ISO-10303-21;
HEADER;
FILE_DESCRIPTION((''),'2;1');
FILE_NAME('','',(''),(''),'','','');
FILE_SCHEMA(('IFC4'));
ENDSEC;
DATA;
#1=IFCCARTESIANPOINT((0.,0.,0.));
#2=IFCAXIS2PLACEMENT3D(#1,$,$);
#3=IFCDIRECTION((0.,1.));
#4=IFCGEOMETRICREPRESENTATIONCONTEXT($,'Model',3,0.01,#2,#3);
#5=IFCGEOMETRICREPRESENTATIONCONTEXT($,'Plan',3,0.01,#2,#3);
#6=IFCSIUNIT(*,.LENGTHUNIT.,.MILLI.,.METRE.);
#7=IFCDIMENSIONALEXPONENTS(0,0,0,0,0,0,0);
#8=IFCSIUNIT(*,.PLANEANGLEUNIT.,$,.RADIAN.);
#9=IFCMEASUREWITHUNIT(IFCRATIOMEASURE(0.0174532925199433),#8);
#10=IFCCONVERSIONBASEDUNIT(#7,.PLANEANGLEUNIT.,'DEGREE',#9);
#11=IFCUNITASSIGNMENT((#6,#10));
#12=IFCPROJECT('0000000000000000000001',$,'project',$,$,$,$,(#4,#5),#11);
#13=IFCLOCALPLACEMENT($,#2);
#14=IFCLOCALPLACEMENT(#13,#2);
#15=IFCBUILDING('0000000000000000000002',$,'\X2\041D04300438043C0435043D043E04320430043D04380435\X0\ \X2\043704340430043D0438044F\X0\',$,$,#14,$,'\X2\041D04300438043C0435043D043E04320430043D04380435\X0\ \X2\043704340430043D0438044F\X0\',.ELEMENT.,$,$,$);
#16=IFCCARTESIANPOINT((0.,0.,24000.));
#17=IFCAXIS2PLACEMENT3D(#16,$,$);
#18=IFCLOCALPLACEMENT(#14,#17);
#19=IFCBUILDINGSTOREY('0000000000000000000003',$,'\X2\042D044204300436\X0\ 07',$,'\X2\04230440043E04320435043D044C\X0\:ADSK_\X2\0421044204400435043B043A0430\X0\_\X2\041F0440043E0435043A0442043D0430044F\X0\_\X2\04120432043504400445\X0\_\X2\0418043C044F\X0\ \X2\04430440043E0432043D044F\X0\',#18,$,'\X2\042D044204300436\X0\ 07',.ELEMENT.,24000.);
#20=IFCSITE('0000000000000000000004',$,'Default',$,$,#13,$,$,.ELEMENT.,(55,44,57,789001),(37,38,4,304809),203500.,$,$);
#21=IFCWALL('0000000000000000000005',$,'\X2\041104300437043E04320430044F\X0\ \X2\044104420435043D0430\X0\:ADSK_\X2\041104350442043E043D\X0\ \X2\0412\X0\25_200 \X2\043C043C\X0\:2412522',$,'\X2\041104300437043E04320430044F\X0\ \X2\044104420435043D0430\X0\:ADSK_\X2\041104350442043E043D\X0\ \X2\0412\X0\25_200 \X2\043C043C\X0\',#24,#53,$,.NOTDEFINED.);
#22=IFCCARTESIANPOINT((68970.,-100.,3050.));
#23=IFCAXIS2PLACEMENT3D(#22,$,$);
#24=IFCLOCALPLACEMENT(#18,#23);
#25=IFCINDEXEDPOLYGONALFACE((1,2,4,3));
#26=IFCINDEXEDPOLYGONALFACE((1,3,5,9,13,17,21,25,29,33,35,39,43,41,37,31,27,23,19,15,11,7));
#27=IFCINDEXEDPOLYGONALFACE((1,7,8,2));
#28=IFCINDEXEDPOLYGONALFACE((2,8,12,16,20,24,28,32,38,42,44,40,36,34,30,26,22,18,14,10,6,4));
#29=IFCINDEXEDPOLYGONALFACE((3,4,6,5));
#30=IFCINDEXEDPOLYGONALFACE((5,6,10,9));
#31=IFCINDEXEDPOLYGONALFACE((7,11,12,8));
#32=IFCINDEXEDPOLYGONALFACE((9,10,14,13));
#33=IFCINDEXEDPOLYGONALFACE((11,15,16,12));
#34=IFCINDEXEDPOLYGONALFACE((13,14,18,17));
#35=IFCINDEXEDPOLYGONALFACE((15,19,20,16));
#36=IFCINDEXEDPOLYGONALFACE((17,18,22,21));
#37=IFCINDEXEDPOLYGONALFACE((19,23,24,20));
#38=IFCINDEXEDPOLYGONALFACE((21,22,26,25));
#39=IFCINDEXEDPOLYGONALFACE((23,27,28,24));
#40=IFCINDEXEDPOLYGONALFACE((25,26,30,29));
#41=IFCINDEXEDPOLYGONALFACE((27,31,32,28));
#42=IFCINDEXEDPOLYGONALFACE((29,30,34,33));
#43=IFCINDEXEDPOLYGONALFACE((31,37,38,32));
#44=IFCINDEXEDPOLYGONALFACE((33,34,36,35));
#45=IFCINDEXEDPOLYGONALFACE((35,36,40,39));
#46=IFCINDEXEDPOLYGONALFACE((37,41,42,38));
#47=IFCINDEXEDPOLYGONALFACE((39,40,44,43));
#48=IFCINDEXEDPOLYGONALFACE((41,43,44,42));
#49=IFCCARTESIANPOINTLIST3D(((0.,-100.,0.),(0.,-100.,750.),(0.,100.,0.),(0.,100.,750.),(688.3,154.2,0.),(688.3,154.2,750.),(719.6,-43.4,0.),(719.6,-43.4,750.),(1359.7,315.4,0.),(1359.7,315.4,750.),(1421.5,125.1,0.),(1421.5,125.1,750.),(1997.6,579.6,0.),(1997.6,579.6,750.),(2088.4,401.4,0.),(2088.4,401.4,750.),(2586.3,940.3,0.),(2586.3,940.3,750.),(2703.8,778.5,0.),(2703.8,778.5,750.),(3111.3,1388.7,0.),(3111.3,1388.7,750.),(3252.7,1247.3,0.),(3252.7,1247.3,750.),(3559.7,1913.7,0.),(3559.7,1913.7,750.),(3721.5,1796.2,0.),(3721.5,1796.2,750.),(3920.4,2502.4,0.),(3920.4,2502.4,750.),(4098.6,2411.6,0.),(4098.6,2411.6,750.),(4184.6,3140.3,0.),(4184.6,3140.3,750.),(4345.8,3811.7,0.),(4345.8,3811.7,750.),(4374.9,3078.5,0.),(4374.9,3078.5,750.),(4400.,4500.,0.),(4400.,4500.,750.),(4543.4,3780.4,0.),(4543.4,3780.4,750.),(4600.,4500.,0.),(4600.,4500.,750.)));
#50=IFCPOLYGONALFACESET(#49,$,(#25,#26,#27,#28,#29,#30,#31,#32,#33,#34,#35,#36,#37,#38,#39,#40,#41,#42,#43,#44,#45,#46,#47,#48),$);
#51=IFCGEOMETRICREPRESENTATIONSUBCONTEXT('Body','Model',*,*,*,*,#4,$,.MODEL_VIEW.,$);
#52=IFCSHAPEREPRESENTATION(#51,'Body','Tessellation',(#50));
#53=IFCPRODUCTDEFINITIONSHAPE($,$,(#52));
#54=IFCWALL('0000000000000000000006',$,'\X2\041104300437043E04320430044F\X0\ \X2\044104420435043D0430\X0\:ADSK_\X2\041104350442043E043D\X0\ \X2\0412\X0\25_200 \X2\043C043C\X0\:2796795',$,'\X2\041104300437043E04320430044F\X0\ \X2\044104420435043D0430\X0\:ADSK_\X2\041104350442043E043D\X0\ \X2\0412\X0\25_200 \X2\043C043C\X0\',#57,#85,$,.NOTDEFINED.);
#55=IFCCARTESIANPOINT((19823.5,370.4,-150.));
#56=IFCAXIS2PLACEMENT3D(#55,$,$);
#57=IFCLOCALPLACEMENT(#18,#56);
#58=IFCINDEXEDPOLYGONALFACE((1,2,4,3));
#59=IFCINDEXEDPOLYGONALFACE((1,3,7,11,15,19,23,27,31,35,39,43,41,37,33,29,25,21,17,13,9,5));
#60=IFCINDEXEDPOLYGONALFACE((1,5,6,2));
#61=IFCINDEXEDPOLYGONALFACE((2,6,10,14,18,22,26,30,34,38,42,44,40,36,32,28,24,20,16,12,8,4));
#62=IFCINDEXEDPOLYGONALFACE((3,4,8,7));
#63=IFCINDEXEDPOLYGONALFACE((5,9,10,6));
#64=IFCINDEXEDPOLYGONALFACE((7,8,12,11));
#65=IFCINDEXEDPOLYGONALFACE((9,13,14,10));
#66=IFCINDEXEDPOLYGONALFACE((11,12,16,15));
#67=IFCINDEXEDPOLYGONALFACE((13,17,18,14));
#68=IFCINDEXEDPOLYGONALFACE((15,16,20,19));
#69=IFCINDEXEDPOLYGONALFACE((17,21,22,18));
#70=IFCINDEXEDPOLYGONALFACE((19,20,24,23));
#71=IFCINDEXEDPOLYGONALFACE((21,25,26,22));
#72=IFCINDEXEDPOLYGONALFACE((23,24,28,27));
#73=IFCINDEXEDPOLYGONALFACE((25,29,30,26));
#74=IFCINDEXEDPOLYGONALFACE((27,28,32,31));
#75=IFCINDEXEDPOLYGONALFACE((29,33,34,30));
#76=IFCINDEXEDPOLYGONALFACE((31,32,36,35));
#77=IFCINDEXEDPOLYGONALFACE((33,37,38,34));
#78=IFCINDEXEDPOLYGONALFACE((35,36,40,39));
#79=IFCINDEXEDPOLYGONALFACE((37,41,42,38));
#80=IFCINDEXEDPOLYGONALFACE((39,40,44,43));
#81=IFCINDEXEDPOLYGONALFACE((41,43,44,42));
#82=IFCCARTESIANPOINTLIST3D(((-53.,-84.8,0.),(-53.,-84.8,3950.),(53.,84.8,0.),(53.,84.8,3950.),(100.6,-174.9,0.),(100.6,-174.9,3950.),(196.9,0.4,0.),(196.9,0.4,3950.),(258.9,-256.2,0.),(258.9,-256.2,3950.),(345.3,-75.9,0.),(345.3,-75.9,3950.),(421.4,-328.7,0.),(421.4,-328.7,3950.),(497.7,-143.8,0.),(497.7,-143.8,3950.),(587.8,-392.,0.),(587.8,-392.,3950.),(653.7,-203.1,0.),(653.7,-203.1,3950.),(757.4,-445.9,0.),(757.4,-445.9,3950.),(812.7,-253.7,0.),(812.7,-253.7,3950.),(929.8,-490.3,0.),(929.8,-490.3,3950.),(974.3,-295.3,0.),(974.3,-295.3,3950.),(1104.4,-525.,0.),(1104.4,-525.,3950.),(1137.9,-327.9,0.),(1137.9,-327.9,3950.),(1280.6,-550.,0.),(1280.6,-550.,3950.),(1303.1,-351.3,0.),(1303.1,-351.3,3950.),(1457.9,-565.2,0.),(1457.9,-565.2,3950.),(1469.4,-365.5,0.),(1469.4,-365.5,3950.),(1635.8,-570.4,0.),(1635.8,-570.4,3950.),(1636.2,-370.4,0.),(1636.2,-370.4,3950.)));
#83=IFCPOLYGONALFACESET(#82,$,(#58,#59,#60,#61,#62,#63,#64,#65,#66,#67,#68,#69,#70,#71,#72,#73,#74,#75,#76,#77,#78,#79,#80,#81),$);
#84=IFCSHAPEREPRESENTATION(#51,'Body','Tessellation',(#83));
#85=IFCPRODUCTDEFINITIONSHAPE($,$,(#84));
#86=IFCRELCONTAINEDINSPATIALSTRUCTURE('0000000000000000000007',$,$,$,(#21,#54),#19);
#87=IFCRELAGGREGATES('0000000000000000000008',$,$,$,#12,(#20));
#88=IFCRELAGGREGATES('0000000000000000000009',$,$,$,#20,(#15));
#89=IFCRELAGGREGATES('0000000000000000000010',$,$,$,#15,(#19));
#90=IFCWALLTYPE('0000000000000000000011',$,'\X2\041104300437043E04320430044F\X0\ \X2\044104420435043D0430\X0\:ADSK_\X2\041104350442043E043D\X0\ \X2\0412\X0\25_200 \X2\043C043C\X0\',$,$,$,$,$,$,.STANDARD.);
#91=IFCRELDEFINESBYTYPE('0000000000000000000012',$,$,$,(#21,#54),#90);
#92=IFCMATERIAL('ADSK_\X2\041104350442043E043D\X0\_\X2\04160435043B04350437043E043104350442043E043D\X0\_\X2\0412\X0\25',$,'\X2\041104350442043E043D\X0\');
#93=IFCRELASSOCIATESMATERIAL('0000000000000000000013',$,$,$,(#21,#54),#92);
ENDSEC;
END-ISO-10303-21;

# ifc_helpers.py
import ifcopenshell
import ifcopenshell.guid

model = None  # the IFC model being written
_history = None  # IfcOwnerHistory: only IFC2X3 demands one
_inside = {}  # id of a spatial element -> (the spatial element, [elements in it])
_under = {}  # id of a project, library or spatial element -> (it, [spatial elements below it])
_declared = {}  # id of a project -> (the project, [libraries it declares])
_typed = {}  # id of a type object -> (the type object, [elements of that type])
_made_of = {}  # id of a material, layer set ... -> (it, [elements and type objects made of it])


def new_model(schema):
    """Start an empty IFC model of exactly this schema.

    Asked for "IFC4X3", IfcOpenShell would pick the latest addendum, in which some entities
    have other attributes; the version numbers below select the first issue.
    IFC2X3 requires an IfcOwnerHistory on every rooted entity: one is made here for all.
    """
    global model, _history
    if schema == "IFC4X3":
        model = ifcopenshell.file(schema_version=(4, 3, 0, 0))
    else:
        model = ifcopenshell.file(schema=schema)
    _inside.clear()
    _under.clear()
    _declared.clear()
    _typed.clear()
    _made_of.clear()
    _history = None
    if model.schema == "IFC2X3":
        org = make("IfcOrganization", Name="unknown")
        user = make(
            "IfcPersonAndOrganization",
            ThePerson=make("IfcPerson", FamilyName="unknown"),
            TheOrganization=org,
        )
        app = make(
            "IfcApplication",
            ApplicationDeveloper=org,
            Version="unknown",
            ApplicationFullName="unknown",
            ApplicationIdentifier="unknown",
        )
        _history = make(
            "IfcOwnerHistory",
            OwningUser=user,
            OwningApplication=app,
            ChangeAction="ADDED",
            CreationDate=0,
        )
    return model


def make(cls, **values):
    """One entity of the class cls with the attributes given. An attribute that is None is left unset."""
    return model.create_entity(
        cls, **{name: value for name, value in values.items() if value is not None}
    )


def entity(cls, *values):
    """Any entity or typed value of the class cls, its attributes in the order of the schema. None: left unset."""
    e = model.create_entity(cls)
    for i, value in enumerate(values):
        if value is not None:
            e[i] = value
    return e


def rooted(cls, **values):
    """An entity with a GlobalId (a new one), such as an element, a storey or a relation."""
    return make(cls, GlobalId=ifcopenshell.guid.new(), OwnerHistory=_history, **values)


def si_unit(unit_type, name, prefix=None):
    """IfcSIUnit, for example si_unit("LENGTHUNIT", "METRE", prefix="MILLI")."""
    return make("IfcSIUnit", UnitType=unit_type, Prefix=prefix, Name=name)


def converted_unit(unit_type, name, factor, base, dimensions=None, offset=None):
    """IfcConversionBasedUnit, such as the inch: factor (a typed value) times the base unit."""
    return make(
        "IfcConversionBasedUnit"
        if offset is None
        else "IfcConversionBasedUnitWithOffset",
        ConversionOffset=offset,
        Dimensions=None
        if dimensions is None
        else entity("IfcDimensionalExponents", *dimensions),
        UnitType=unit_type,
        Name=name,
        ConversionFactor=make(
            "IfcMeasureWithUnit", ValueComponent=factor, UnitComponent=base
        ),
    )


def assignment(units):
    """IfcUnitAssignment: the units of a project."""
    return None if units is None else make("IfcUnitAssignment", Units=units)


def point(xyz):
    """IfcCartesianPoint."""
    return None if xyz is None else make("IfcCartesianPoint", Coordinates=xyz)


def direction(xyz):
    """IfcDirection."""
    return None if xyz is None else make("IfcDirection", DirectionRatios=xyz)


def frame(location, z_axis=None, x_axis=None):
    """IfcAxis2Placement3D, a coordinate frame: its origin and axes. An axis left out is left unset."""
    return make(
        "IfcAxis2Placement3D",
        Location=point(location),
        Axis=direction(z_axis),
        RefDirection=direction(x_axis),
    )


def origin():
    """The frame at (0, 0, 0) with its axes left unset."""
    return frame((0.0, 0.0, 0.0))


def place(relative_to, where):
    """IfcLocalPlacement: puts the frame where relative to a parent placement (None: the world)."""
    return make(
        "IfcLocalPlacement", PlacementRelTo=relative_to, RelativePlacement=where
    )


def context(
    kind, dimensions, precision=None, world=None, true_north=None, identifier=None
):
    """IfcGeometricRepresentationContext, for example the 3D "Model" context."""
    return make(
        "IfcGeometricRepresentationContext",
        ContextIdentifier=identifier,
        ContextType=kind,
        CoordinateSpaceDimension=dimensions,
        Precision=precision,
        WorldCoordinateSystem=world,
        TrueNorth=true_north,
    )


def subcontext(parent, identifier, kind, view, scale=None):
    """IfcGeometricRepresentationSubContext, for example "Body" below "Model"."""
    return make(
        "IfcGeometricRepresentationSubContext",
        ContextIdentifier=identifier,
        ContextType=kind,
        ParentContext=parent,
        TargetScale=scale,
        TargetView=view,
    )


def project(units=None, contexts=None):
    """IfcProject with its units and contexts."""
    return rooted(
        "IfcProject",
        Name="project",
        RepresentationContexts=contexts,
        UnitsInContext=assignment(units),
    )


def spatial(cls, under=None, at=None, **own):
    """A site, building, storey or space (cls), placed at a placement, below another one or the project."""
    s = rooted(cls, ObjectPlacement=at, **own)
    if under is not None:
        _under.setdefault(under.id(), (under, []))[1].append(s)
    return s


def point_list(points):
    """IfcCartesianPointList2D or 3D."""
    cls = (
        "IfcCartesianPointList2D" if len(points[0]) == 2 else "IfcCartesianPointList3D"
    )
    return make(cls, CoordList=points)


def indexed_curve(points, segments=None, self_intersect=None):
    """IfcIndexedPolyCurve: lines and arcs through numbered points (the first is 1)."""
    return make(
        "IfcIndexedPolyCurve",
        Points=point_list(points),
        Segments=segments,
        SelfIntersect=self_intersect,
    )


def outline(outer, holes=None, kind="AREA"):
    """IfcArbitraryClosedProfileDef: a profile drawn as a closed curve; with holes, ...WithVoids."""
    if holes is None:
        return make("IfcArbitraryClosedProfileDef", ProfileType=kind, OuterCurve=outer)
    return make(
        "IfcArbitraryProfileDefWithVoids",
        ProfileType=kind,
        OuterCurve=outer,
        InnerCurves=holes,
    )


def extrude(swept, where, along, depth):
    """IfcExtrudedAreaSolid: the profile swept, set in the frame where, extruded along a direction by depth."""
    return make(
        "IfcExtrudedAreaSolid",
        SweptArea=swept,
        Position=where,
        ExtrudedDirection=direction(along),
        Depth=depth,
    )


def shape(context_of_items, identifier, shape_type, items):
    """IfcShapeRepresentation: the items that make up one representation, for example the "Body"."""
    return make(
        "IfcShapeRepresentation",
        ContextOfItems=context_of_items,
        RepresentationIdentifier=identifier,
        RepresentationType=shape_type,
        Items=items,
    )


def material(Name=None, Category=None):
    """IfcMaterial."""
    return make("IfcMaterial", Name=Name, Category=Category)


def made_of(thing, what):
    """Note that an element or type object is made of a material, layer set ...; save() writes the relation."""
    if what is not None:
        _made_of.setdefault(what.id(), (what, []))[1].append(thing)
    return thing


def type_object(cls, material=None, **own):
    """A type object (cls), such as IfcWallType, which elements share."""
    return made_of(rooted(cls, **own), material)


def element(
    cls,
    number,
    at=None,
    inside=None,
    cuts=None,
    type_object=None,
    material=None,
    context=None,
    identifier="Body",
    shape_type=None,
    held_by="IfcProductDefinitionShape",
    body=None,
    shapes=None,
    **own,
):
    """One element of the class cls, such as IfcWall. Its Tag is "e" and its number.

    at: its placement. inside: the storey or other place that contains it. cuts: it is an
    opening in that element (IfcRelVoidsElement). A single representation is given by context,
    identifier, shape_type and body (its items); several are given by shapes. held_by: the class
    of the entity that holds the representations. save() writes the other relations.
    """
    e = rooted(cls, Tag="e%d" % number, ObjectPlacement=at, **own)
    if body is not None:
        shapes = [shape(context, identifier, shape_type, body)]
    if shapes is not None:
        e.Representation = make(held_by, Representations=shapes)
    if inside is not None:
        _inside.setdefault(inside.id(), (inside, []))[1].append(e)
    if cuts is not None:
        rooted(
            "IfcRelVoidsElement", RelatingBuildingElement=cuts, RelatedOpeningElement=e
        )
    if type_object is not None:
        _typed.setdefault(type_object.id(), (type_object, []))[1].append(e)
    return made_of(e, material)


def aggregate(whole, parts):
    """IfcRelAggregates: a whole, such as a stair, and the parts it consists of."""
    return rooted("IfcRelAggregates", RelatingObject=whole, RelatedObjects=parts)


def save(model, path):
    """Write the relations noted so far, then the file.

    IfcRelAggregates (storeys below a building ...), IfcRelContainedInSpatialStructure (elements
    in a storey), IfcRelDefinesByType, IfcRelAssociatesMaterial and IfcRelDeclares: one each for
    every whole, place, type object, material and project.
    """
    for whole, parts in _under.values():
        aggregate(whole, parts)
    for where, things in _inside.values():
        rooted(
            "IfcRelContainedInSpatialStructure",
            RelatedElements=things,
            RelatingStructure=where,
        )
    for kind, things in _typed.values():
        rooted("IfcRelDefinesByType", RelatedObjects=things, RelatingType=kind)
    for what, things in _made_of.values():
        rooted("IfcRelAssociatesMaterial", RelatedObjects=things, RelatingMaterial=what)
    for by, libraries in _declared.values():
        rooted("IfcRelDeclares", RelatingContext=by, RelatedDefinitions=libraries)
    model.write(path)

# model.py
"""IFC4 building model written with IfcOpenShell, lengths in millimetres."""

from ifc_helpers import new_model, entity, si_unit, converted_unit, direction, frame, origin, place, context, subcontext, project, spatial, indexed_curve, outline, extrude, material, type_object, element, save


model = new_model("IFC4")

# Units and contexts
model_context = context("Model", 3, precision=0.01, world=origin(), true_north=direction((0.0, 1.0)))
plan_context = context("Plan", 3, precision=0.01, world=origin(), true_north=direction((0.0, 1.0)))
body_context = subcontext(model_context, "Body", "Model", "MODEL_VIEW")
ifc_project = project(units=[si_unit("LENGTHUNIT", "METRE", prefix="MILLI"), converted_unit("PLANEANGLEUNIT", "DEGREE", entity("IfcRatioMeasure", 0.0174532925199433), si_unit("PLANEANGLEUNIT", "RADIAN"), dimensions=[0, 0, 0, 0, 0, 0, 0])], contexts=[model_context, plan_context])

# Site, building, storey
site_placement = place(None, origin())
site = spatial("IfcSite", under=ifc_project, at=site_placement, Name="Default", CompositionType="ELEMENT", RefLatitude=(55, 44, 57, 789001), RefLongitude=(37, 38, 4, 304809), RefElevation=203500.0)
building_placement = place(site_placement, origin())
building = spatial("IfcBuilding", under=site, at=building_placement, Name="Наименование здания", LongName="Наименование здания", CompositionType="ELEMENT")
storey_placement = place(building_placement, frame((0.0, 0.0, 24000.0)))
storey = spatial("IfcBuildingStorey", under=building, at=storey_placement, Name="Этаж 07", ObjectType="Уровень:ADSK_Стрелка_Проектная_Вверх_Имя уровня", LongName="Этаж 07", CompositionType="ELEMENT", Elevation=24000.0)

# Shared definitions
ifc_material = material(Name="ADSK_Бетон_Железобетон_В25", Category="Бетон")

# Walls
wall_type = type_object("IfcWallType", Name="Базовая стена:ADSK_Бетон В25_200 мм", PredefinedType="STANDARD")
wall_1_placement = place(storey_placement, frame((68970.0, -100.0, 3050.0)))
element("IfcWall", 1, at=wall_1_placement, inside=storey, type_object=wall_type, material=ifc_material, Name="Базовая стена:ADSK_Бетон В25_200 мм:2412522", ObjectType="Базовая стена:ADSK_Бетон В25_200 мм", PredefinedType="NOTDEFINED", context=body_context, shape_type="SweptSolid", body=[
    extrude(outline(indexed_curve([(4400.0, 4500.0), (4345.8, 3811.7), (4184.6, 3140.3), (3920.4, 2502.4), (3559.7, 1913.7), (3111.3, 1388.7), (2586.3, 940.3), (1997.6, 579.6), (1359.7, 315.4), (688.3, 154.2), (0.0, 100.0), (0.0, -100.0), (719.6, -43.4), (1421.5, 125.1), (2088.4, 401.4), (2703.8, 778.5), (3252.7, 1247.3), (3721.5, 1796.2), (4098.6, 2411.6), (4374.9, 3078.5), (4543.4, 3780.4), (4600.0, 4500.0), (4400.0, 4500.0)], self_intersect=False)), origin(), (0.0, 0.0, 1.0), 750.0),
])
wall_2_placement = place(storey_placement, frame((19823.5, 370.4, -150.0)))
element("IfcWall", 2, at=wall_2_placement, inside=storey, type_object=wall_type, material=ifc_material, Name="Базовая стена:ADSK_Бетон В25_200 мм:2796795", ObjectType="Базовая стена:ADSK_Бетон В25_200 мм", PredefinedType="NOTDEFINED", context=body_context, shape_type="SweptSolid", body=[
    extrude(outline(indexed_curve([(1636.2, -370.4), (1469.4, -365.5), (1303.1, -351.3), (1137.9, -327.9), (974.3, -295.3), (812.7, -253.7), (653.7, -203.1), (497.7, -143.8), (345.3, -75.9), (196.9, 0.4), (53.0, 84.8), (-53.0, -84.8), (100.6, -174.9), (258.9, -256.2), (421.4, -328.7), (587.8, -392.0), (757.4, -445.9), (929.8, -490.3), (1104.4, -525.0), (1280.6, -550.0), (1457.9, -565.2), (1635.8, -570.4), (1636.2, -370.4)], self_intersect=False)), origin(), (0.0, 0.0, 1.0), 3950.0),
])

save(model, "model.ifc")
